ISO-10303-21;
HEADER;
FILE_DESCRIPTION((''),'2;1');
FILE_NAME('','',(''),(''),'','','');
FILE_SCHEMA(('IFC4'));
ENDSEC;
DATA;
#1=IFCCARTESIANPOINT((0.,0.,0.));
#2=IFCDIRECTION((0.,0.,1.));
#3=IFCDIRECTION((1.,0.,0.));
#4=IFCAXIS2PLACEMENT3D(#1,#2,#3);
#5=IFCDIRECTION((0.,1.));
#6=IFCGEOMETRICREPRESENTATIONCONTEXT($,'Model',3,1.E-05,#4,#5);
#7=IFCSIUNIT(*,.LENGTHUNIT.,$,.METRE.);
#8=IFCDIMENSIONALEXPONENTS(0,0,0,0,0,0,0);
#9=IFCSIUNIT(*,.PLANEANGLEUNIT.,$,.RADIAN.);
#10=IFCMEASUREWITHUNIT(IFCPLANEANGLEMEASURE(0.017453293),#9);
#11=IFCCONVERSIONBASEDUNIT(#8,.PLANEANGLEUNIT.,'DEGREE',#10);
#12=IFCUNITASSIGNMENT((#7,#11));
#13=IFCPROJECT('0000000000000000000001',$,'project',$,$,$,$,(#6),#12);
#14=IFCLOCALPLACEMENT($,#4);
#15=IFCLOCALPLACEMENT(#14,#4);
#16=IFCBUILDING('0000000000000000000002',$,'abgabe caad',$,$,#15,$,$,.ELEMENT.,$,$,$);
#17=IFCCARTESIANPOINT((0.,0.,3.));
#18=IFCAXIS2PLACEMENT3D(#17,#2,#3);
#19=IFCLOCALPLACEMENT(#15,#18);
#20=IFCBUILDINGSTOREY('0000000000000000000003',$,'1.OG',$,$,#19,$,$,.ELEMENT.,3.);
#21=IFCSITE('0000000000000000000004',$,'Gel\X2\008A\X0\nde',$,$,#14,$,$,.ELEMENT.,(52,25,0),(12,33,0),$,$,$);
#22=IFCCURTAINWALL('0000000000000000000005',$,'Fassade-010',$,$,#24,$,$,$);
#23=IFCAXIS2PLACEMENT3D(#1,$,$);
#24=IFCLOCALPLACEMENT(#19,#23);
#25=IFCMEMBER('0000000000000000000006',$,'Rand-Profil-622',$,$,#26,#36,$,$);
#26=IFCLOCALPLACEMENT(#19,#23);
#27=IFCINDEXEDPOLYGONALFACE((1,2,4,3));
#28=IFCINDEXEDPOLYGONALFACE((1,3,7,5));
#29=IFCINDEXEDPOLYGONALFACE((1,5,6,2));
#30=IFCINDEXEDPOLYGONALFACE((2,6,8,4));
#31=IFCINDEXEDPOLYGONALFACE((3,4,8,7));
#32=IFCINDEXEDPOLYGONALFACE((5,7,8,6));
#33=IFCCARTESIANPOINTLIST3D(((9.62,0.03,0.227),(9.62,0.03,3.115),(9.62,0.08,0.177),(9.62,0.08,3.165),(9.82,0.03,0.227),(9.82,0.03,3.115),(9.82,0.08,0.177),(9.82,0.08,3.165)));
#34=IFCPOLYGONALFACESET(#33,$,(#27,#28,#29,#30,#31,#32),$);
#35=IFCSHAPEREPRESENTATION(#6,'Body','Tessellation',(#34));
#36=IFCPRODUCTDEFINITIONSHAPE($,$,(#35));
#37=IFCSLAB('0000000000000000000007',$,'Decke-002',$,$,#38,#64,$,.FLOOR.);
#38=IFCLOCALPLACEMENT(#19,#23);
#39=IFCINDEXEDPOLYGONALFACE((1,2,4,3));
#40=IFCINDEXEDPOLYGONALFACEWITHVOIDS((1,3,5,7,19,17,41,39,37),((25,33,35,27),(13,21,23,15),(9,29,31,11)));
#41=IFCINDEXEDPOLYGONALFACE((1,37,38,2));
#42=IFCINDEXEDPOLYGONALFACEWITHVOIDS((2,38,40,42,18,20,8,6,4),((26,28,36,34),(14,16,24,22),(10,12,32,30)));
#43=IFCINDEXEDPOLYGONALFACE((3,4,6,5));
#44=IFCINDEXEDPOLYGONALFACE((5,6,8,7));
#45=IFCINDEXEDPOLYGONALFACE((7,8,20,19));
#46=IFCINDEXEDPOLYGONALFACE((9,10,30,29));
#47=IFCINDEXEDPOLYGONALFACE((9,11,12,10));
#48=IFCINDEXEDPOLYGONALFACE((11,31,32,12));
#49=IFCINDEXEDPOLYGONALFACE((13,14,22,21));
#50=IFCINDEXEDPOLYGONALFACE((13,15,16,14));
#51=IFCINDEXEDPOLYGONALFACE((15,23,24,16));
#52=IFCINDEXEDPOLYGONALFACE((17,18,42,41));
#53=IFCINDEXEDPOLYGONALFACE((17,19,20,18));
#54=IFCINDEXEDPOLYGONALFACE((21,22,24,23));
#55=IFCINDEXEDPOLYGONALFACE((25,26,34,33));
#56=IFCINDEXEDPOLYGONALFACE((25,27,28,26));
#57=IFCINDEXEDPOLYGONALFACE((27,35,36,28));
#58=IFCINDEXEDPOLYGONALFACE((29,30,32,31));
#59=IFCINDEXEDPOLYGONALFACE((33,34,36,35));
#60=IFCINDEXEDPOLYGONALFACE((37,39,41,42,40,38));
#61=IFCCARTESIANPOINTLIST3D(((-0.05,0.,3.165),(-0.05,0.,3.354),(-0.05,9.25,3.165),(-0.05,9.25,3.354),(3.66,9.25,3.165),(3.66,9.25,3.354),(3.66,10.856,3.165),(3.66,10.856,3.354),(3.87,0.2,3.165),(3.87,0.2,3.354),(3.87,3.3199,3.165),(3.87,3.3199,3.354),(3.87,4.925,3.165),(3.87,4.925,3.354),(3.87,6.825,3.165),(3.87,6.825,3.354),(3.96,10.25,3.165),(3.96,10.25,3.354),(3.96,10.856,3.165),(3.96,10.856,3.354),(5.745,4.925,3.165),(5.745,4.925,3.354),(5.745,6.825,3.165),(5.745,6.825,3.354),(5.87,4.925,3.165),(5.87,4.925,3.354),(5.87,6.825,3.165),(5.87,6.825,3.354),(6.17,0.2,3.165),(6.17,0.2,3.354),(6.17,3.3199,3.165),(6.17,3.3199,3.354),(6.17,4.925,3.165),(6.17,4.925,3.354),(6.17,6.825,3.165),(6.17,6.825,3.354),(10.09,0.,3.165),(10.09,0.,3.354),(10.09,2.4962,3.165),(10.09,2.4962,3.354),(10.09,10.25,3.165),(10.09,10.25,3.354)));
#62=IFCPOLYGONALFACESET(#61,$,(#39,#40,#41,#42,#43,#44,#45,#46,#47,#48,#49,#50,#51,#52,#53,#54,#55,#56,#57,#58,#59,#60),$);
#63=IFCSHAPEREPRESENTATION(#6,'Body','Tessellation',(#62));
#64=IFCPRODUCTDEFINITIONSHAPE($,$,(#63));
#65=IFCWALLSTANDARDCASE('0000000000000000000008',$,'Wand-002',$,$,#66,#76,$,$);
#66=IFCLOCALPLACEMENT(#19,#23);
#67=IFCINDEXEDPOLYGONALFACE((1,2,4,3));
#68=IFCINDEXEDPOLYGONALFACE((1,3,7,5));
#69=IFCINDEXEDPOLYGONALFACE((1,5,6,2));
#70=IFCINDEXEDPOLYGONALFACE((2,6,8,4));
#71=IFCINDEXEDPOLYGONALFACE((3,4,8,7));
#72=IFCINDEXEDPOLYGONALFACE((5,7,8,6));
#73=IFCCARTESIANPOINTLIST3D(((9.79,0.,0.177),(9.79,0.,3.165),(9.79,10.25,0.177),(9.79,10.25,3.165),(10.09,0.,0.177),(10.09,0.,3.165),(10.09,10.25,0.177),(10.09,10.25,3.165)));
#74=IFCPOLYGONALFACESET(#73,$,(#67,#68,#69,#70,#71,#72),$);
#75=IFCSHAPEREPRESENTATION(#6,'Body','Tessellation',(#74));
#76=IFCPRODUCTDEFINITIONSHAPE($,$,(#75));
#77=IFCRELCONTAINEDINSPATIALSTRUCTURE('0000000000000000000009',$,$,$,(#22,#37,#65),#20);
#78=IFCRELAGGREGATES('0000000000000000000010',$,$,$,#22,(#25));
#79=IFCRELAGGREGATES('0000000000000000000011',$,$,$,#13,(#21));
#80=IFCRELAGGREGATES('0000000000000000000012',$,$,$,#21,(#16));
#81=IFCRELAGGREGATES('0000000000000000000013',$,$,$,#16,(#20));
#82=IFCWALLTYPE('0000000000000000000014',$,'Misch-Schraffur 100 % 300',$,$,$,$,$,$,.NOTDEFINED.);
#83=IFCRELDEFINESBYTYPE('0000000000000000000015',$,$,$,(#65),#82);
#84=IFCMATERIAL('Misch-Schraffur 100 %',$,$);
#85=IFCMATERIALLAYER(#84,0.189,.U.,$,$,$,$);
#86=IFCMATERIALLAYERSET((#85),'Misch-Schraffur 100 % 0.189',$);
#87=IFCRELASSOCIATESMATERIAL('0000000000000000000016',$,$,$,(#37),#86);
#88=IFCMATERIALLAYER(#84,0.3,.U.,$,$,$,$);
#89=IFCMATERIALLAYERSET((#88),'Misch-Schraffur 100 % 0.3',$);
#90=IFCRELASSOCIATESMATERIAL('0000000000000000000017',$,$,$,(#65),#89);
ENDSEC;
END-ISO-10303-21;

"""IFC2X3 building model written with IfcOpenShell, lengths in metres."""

from ifc_helpers import new_model, entity, si_unit, converted_unit, direction, frame, origin_with_axes, place, context, project, spatial, polyline, outline, extrude, clip, halfspace, material, layer, layer_set, layer_usage, type_object, element, aggregate, save


model = new_model("IFC2X3")

# Units and contexts
model_context = context("Model", 3, precision=1e-05, world=origin_with_axes(), true_north=direction((0.0, 1.0)))
ifc_project = project(units=[si_unit("LENGTHUNIT", "METRE"), converted_unit("PLANEANGLEUNIT", "DEGREE", entity("IfcPlaneAngleMeasure", 0.017453293), si_unit("PLANEANGLEUNIT", "RADIAN"), dimensions=[0, 0, 0, 0, 0, 0, 0])], contexts=[model_context])

# Site, building, storey
site_placement = place(None, origin_with_axes())
site = spatial("IfcSite", under=ifc_project, at=site_placement, Name="Gel\u008ande", CompositionType="ELEMENT", RefLatitude=(52, 25, 0), RefLongitude=(12, 33, 0))
building_placement = place(site_placement, origin_with_axes())
building = spatial("IfcBuilding", under=site, at=building_placement, Name="abgabe caad", CompositionType="ELEMENT")
storey_placement = place(building_placement, frame((0.0, 0.0, 3.0), z_axis=(0.0, 0.0, 1.0), x_axis=(1.0, 0.0, 0.0)))
storey = spatial("IfcBuildingStorey", under=building, at=storey_placement, Name="1.OG", CompositionType="ELEMENT", Elevation=3.0)

# Curtain wall
curtain_wall_1_placement = place(storey_placement, frame((9.205, 0.055, 0.202), z_axis=(0.0, 0.0, 1.0), x_axis=(1.0, 0.0, 0.0)))
curtain_wall_1 = element("IfcCurtainWall", 1, at=curtain_wall_1_placement, inside=storey, Name="Fassade-010")

# Member
member_1_placement = place(curtain_wall_1_placement, frame((0.56, 0.0, 0.0), z_axis=(0.0, 0.0, 1.0), x_axis=(0.0, -1.0, 0.0)))
member_1 = element("IfcMember", 2, at=member_1_placement, Name="Rand-Profil-622", context=model_context, shape_type="Clipping", body=[
    clip(clip(extrude(outline(polyline([(-0.145, -0.025), (0.055, -0.025), (0.055, 0.025), (-0.145, 0.025), (-0.145, -0.025)])), frame((0.0, 0.0, -0.025), z_axis=(0.0, 0.0, 1.0), x_axis=(0.0, 1.0, 0.0)), (0.0, 0.0, 1.0), 2.988), halfspace(frame((0.0, 0.0, 0.0), z_axis=(-0.707107, 0.0, 0.707107), x_axis=(-0.707107, 0.0, -0.707107)), True)), halfspace(frame((1.469, 0.0, 1.469), z_axis=(-0.707107, 0.0, -0.707107), x_axis=(0.707107, 0.0, -0.707107)), True)),
])

# Slab
ifc_material_1 = material(Name="Misch-Schraffur 100 %")
ifc_layer_1 = layer(ifc_material_1, 0.189, ventilated="UNKNOWN")
ifc_layer_set_1 = layer_set([ifc_layer_1], Name="Misch-Schraffur 100 % 0.189")
ifc_layer_usage_1 = layer_usage(ifc_layer_set_1, "AXIS3", "NEGATIVE", 0.189)
slab_placement = place(storey_placement, frame((10.09, 2.4962, 3.165), z_axis=(0.0, 0.0, 1.0), x_axis=(1.0, 0.0, 0.0)))
element("IfcSlab", 3, at=slab_placement, inside=storey, material=ifc_layer_usage_1, Name="Decke-002", PredefinedType="FLOOR", context=model_context, shape_type="SweptSolid", body=[
    extrude(outline(polyline([(0.0, 0.0), (0.0, 7.7538), (-6.13, 7.7538), (-6.13, 8.3598), (-6.43, 8.3598), (-6.43, 6.7538), (-10.14, 6.7538), (-10.14, -2.4962), (0.0, -2.4962), (0.0, 0.0)]), holes=[polyline([(-4.22, 4.3288), (-3.92, 4.3288), (-3.92, 2.4288), (-4.22, 2.4288), (-4.22, 4.3288)]), polyline([(-4.345, 4.3288), (-4.345, 2.4288), (-6.22, 2.4288), (-6.22, 4.3288), (-4.345, 4.3288)]), polyline([(-6.22, -2.2962), (-6.22, 0.8236), (-3.92, 0.8236), (-3.92, -2.2962), (-6.22, -2.2962)])]), origin_with_axes(), (0.0, 0.0, 1.0), 0.189),
])

aggregate(curtain_wall_1, [member_1])

# Wall
ifc_layer_2 = layer(ifc_material_1, 0.3, ventilated="UNKNOWN")
ifc_layer_set_2 = layer_set([ifc_layer_2], Name="Misch-Schraffur 100 % 0.3")
ifc_layer_usage_2 = layer_usage(ifc_layer_set_2, "AXIS2", "NEGATIVE", 0.0)
wall_type = type_object("IfcWallType", Name="Misch-Schraffur 100 % 300", PredefinedType="NOTDEFINED")
wall_placement = place(storey_placement, frame((9.79, 0.0, 0.177), z_axis=(0.0, 0.0, 1.0), x_axis=(0.0, 1.0, 0.0)))
element("IfcWallStandardCase", 4, at=wall_placement, inside=storey, type_object=wall_type, material=ifc_layer_usage_2, Name="Wand-002", context=model_context, shape_type="SweptSolid", body=[
    extrude(outline(polyline([(0.0, -0.3), (10.25, -0.3), (10.25, 0.0), (0.0, 0.0), (0.0, -0.3)])), origin_with_axes(), (0.0, 0.0, 1.0), 2.988),
])

save(model, "model.ifc")
